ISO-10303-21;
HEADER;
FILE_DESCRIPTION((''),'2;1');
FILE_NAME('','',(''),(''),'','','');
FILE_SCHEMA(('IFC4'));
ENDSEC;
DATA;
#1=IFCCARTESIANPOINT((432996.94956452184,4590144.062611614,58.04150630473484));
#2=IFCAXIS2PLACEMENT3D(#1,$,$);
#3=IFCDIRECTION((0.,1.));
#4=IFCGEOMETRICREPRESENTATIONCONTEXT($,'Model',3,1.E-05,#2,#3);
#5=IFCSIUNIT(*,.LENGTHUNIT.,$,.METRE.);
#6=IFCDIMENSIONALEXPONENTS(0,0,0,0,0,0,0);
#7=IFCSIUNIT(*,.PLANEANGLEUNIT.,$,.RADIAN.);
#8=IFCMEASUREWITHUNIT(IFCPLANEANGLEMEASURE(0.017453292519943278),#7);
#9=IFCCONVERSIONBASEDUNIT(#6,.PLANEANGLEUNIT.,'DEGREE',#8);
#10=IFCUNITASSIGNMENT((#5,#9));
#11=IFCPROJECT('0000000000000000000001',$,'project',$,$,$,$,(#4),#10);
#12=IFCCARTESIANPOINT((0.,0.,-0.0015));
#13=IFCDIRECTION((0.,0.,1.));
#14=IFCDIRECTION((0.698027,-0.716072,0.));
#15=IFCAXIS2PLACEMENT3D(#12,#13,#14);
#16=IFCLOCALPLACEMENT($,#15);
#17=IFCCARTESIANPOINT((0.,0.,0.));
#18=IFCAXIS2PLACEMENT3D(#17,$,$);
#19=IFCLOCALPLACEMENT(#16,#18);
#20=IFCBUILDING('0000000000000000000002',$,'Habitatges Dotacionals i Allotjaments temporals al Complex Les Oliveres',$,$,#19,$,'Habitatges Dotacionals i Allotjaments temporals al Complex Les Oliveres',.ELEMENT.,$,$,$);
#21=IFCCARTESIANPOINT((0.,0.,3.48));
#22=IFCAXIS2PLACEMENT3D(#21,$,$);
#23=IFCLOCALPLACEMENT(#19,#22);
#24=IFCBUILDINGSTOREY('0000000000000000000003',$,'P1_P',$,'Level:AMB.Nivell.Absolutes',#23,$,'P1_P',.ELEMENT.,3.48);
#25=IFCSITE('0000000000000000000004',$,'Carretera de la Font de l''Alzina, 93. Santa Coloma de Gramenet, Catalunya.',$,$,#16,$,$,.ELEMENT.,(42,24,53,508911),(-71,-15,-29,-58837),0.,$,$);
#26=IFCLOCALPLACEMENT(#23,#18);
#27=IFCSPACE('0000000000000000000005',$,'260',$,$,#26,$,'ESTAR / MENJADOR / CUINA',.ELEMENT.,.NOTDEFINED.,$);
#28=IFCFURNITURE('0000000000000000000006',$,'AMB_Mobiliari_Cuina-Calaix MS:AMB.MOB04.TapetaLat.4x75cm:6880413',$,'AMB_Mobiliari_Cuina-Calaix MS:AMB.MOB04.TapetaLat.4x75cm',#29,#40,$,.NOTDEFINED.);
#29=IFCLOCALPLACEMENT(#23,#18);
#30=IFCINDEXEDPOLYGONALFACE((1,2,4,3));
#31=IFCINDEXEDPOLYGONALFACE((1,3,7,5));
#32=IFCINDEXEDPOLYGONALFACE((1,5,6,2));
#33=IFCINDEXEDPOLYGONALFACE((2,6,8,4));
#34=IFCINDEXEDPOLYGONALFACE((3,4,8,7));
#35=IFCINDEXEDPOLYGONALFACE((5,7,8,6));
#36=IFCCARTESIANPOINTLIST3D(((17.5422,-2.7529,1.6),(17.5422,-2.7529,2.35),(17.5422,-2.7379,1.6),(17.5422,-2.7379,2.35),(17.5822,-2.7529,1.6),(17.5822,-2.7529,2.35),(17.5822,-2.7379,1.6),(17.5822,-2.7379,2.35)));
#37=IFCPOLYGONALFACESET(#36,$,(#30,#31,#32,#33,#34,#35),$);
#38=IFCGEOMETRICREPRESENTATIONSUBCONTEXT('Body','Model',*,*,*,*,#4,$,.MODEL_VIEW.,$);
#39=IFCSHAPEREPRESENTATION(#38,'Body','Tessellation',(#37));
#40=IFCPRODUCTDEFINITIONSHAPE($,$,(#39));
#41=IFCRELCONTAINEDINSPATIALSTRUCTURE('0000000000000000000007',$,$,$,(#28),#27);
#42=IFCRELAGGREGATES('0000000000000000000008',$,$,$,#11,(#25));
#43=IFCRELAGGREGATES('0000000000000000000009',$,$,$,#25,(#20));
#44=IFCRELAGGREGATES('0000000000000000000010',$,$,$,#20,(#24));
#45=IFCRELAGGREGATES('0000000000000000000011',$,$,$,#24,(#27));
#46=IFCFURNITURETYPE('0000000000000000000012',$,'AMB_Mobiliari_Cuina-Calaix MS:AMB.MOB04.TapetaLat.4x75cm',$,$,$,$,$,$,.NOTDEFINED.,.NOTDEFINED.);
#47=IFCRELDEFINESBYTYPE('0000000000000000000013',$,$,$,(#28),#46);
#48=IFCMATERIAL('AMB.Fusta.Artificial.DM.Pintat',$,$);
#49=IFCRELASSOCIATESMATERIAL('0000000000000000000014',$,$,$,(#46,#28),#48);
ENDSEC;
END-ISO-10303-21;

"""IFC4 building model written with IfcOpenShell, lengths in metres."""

from ifc_helpers import new_model, entity, si_unit, converted_unit, direction, frame, origin, place, context, subcontext, project, spatial, indexed_curve, outline, extrude, source, transform, mapped, material, type_object, type_shapes, element, save


model = new_model("IFC4")

# Units and contexts
model_context = context("Model", 3, precision=1e-05, world=frame((432996.94956452184, 4590144.062611614, 58.04150630473484)), true_north=direction((0.0, 1.0)))
body_context = subcontext(model_context, "Body", "Model", "MODEL_VIEW")
ifc_project = project(units=[si_unit("LENGTHUNIT", "METRE"), converted_unit("PLANEANGLEUNIT", "DEGREE", entity("IfcPlaneAngleMeasure", 0.017453292519943278), si_unit("PLANEANGLEUNIT", "RADIAN"), dimensions=[0, 0, 0, 0, 0, 0, 0])], contexts=[model_context])

# Site, building, storey
site_placement = place(None, frame((0.0, 0.0, -0.0015), z_axis=(0.0, 0.0, 1.0), x_axis=(0.698027, -0.716072, 0.0)))
site = spatial("IfcSite", under=ifc_project, at=site_placement, Name="Carretera de la Font de l'Alzina, 93. Santa Coloma de Gramenet, Catalunya.", CompositionType="ELEMENT", RefLatitude=(42, 24, 53, 508911), RefLongitude=(-71, -15, -29, -58837), RefElevation=0.0)
building_placement = place(site_placement, origin())
building = spatial("IfcBuilding", under=site, at=building_placement, Name="Habitatges Dotacionals i Allotjaments temporals al Complex Les Oliveres", LongName="Habitatges Dotacionals i Allotjaments temporals al Complex Les Oliveres", CompositionType="ELEMENT")
storey_placement = place(building_placement, frame((0.0, 0.0, 3.48)))
storey = spatial("IfcBuildingStorey", under=building, at=storey_placement, Name="P1_P", ObjectType="Level:AMB.Nivell.Absolutes", LongName="P1_P", CompositionType="ELEMENT", Elevation=3.48)

# Shared definitions
ifc_material_1 = material(Name="AMB.Fusta.Artificial.DM.Pintat")

# Shared definitions
space_1_placement = place(storey_placement, origin())
space_1 = spatial("IfcSpace", under=storey, at=space_1_placement, Name="260", LongName="ESTAR / MENJADOR / CUINA", CompositionType="ELEMENT", PredefinedType="NOTDEFINED")

# Furniture
furniture_type_1 = type_object("IfcFurnitureType", Name="AMB_Mobiliari_Cuina-Calaix MS:AMB.MOB04.TapetaLat.4x75cm", AssemblyPlace="NOTDEFINED", PredefinedType="NOTDEFINED", material=ifc_material_1)
shared_shape_1 = source(origin(), body_context, "Body", "SweptSolid", [
    extrude(outline(indexed_curve([(-0.0075, -0.02), (0.0075, -0.02), (0.0075, 0.02), (-0.0075, 0.02), (-0.0075, -0.02)], self_intersect=False)), frame((-0.8045, 0.0075, 0.0), z_axis=(0.0, 0.0, 1.0), x_axis=(0.0, 1.0, 0.0)), (0.0, 0.0, 1.0), 0.75),
])
type_shapes(furniture_type_1, [shared_shape_1])
furniture_1_placement = place(space_1_placement, frame((16.7577, -2.7379, 1.6), z_axis=(0.0, 0.0, 1.0), x_axis=(-1.0, 0.0, 0.0)))
element("IfcFurniture", 1, at=furniture_1_placement, inside=space_1, type_object=furniture_type_1, material=ifc_material_1, Name="AMB_Mobiliari_Cuina-Calaix MS:AMB.MOB04.TapetaLat.4x75cm:6880413", ObjectType="AMB_Mobiliari_Cuina-Calaix MS:AMB.MOB04.TapetaLat.4x75cm", PredefinedType="NOTDEFINED", context=body_context, shape_type="MappedRepresentation", body=[
    mapped(shared_shape_1, transform((0.0, 0.0, 0.0), scale=1.0)),
])

save(model, "model.ifc")
